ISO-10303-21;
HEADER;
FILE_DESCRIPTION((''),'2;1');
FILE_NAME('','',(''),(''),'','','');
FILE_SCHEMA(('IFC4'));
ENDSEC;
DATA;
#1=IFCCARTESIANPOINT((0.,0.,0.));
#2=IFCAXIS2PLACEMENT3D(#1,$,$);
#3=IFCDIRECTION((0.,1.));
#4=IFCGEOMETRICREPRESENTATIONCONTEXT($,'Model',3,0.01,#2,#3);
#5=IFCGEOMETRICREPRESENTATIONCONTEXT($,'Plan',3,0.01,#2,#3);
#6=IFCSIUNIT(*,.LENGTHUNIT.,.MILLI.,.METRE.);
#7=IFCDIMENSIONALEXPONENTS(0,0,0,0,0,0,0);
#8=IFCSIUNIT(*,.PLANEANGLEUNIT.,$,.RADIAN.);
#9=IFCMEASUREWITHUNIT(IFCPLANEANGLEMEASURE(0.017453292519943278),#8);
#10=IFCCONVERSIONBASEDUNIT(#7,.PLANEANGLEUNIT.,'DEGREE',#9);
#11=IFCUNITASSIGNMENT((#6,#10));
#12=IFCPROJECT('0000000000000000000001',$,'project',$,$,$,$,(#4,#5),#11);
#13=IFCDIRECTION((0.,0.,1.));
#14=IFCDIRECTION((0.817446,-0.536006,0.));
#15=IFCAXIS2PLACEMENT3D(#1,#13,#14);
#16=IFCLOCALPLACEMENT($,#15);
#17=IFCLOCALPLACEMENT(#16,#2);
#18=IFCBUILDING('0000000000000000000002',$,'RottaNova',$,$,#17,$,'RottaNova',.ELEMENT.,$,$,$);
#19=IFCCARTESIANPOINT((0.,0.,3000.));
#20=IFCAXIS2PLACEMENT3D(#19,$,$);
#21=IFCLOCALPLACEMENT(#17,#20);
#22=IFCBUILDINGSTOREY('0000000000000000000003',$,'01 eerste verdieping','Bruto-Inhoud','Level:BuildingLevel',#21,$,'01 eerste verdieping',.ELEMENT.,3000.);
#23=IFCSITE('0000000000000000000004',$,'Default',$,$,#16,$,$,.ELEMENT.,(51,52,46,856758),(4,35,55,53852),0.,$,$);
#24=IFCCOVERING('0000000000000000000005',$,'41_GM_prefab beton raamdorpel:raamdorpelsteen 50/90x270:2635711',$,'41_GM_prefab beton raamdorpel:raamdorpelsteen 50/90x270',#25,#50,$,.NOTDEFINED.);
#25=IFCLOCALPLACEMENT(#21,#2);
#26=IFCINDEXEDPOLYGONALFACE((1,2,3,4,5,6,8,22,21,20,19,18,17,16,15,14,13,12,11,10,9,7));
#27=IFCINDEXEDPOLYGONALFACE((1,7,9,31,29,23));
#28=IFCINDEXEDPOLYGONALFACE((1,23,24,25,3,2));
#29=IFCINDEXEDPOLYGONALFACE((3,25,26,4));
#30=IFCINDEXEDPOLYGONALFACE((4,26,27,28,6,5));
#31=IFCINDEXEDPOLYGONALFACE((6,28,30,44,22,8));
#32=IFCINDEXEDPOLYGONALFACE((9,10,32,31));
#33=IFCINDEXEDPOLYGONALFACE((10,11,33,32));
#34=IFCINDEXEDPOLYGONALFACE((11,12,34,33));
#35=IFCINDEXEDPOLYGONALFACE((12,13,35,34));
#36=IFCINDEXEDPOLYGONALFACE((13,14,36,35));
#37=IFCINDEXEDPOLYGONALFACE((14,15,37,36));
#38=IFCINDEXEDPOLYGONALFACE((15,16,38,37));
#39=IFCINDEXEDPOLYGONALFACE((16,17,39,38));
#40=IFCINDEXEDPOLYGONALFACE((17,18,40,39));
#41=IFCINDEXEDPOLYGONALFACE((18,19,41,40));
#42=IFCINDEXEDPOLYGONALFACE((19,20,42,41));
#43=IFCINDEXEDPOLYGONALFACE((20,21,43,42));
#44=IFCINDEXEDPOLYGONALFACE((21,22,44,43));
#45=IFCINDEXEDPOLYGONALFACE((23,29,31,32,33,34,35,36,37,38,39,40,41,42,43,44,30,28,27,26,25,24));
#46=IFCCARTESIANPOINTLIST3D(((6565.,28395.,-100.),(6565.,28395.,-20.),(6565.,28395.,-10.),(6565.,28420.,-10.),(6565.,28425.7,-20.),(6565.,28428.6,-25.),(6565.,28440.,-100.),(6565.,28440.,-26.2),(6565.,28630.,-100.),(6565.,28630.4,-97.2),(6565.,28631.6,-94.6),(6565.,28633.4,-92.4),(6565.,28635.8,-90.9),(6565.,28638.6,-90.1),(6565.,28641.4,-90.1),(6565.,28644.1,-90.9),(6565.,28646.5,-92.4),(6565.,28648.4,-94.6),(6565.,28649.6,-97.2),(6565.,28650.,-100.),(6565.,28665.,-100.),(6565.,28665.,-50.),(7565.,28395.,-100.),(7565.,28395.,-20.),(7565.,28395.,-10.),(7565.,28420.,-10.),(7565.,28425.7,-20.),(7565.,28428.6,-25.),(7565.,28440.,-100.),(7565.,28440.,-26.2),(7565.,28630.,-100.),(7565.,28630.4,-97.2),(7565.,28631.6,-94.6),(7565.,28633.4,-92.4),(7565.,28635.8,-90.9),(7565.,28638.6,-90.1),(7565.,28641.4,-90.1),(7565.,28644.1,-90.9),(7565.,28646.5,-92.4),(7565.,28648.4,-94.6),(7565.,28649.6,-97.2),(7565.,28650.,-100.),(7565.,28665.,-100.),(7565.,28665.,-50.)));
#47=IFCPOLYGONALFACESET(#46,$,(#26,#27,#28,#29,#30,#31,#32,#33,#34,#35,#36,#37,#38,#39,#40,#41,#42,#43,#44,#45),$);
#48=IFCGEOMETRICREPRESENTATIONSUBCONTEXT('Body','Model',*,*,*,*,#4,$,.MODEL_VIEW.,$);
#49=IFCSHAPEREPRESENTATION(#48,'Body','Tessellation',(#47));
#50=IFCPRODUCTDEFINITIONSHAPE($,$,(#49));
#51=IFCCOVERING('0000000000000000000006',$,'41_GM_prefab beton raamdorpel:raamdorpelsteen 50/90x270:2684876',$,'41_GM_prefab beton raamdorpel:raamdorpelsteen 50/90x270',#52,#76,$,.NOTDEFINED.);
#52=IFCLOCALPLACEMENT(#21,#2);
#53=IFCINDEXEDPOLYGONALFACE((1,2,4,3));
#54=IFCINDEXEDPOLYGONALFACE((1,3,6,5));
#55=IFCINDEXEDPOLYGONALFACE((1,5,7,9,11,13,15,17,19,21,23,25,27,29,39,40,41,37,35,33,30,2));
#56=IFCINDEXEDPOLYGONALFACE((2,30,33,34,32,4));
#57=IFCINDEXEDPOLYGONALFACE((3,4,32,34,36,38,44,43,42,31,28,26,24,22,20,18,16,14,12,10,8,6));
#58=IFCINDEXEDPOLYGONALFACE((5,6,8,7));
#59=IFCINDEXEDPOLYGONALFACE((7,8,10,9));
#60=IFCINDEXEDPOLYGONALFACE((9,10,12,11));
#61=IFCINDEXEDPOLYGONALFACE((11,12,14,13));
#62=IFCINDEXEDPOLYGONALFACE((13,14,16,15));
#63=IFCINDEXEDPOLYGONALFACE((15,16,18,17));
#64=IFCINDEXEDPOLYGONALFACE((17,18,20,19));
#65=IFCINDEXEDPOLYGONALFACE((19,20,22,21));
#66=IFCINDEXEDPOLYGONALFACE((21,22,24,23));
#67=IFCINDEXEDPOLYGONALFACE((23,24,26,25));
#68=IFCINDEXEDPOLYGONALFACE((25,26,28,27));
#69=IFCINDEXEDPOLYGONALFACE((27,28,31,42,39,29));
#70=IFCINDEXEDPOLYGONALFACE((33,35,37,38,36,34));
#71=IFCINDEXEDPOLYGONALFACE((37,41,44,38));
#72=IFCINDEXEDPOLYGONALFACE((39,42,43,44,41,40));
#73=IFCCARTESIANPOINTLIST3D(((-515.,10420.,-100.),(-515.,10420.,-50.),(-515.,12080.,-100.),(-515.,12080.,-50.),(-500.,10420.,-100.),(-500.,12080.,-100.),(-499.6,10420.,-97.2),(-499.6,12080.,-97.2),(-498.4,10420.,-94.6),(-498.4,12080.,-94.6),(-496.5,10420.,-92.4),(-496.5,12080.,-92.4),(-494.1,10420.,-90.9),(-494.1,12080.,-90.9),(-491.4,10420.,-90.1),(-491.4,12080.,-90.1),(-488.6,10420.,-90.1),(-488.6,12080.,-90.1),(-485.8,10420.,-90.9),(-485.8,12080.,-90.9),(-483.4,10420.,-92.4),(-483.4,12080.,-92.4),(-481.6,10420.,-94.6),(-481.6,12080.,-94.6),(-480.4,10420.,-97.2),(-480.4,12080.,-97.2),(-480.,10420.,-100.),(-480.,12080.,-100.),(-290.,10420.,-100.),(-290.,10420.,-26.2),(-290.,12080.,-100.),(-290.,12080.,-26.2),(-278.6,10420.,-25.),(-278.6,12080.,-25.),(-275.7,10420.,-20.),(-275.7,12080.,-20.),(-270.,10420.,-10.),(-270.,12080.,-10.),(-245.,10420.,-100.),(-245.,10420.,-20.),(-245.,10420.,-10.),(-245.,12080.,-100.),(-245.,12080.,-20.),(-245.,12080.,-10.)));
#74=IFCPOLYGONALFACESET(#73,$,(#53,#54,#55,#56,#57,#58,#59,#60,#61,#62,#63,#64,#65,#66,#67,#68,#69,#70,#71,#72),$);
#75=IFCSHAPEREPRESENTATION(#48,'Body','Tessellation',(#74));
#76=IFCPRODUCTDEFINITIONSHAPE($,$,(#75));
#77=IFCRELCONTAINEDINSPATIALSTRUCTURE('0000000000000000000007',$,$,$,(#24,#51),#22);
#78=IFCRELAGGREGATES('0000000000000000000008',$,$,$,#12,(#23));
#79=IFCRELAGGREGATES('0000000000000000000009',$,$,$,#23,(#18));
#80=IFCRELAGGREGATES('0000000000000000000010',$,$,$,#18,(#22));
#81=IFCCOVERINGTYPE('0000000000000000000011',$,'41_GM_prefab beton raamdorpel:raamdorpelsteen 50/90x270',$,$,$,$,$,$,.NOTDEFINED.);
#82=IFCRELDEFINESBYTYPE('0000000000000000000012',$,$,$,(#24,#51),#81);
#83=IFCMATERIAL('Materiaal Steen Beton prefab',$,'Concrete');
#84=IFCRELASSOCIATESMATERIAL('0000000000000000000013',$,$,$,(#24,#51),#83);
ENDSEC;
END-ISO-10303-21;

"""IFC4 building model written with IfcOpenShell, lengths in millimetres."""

from ifc_helpers import new_model, entity, si_unit, converted_unit, direction, frame, origin, place, context, subcontext, project, spatial, line, arc, indexed_curve, outline, extrude, material, type_object, element, save


model = new_model("IFC4")

# Units and contexts
model_context = context("Model", 3, precision=0.01, world=origin(), true_north=direction((0.0, 1.0)))
plan_context = context("Plan", 3, precision=0.01, world=origin(), true_north=direction((0.0, 1.0)))
body_context = subcontext(model_context, "Body", "Model", "MODEL_VIEW")
ifc_project = project(units=[si_unit("LENGTHUNIT", "METRE", prefix="MILLI"), converted_unit("PLANEANGLEUNIT", "DEGREE", entity("IfcPlaneAngleMeasure", 0.017453292519943278), si_unit("PLANEANGLEUNIT", "RADIAN"), dimensions=[0, 0, 0, 0, 0, 0, 0])], contexts=[model_context, plan_context])

# Site, building, storey
site_placement = place(None, frame((0.0, 0.0, 0.0), z_axis=(0.0, 0.0, 1.0), x_axis=(0.817446, -0.536006, 0.0)))
site = spatial("IfcSite", under=ifc_project, at=site_placement, Name="Default", CompositionType="ELEMENT", RefLatitude=(51, 52, 46, 856758), RefLongitude=(4, 35, 55, 53852), RefElevation=0.0)
building_placement = place(site_placement, origin())
building = spatial("IfcBuilding", under=site, at=building_placement, Name="RottaNova", LongName="RottaNova", CompositionType="ELEMENT")
storey_placement = place(building_placement, frame((0.0, 0.0, 3000.0)))
storey = spatial("IfcBuildingStorey", under=building, at=storey_placement, Name="01 eerste verdieping", Description="Bruto-Inhoud", ObjectType="Level:BuildingLevel", LongName="01 eerste verdieping", CompositionType="ELEMENT", Elevation=3000.0)

# Coverings
ifc_material_1 = material(Name="Materiaal Steen Beton prefab", Category="Concrete")
covering_type_1 = type_object("IfcCoveringType", Name="41_GM_prefab beton raamdorpel:raamdorpelsteen 50/90x270", PredefinedType="NOTDEFINED")
covering_1_placement = place(storey_placement, origin())
element("IfcCovering", 1, at=covering_1_placement, inside=storey, type_object=covering_type_1, material=ifc_material_1, Name="41_GM_prefab beton raamdorpel:raamdorpelsteen 50/90x270:2635711", ObjectType="41_GM_prefab beton raamdorpel:raamdorpelsteen 50/90x270", PredefinedType="NOTDEFINED", context=body_context, shape_type="SweptSolid", body=[
    extrude(outline(indexed_curve([(75.8, -45.1), (100.8, -45.1), (100.8, -35.1), (100.8, 44.9), (55.8, 44.9), (-134.2, 44.9), (-144.2, 34.9), (-154.2, 44.9), (-169.2, 44.9), (-169.2, -5.1), (55.8, -28.9), (67.1, -30.1), (70.0, -35.1)], segments=[line(1, 2, 3, 4, 5, 6), arc(6, 7, 8), line(8, 9, 10, 11, 12, 13, 1)], self_intersect=False)), frame((6565.0, 28495.8, -55.1), z_axis=(1.0, 0.0, 0.0), x_axis=(0.0, -1.0, 0.0)), (0.0, 0.0, 1.0), 1000.0),
])
covering_2_placement = place(storey_placement, origin())
element("IfcCovering", 2, at=covering_2_placement, inside=storey, type_object=covering_type_1, material=ifc_material_1, Name="41_GM_prefab beton raamdorpel:raamdorpelsteen 50/90x270:2684876", ObjectType="41_GM_prefab beton raamdorpel:raamdorpelsteen 50/90x270", PredefinedType="NOTDEFINED", context=body_context, shape_type="SweptSolid", body=[
    extrude(outline(indexed_curve([(75.8, -45.1), (100.8, -45.1), (100.8, -35.1), (100.8, 44.9), (55.8, 44.9), (-134.2, 44.9), (-144.2, 34.9), (-154.2, 44.9), (-169.2, 44.9), (-169.2, -5.1), (55.8, -28.9), (67.1, -30.1), (70.0, -35.1)], segments=[line(1, 2, 3, 4, 5, 6), arc(6, 7, 8), line(8, 9, 10, 11, 12, 13, 1)], self_intersect=False)), frame((-345.8, 10420.0, -55.1), z_axis=(0.0, 1.0, 0.0), x_axis=(1.0, 0.0, 0.0)), (0.0, 0.0, 1.0), 1660.0),
])

save(model, "model.ifc")
